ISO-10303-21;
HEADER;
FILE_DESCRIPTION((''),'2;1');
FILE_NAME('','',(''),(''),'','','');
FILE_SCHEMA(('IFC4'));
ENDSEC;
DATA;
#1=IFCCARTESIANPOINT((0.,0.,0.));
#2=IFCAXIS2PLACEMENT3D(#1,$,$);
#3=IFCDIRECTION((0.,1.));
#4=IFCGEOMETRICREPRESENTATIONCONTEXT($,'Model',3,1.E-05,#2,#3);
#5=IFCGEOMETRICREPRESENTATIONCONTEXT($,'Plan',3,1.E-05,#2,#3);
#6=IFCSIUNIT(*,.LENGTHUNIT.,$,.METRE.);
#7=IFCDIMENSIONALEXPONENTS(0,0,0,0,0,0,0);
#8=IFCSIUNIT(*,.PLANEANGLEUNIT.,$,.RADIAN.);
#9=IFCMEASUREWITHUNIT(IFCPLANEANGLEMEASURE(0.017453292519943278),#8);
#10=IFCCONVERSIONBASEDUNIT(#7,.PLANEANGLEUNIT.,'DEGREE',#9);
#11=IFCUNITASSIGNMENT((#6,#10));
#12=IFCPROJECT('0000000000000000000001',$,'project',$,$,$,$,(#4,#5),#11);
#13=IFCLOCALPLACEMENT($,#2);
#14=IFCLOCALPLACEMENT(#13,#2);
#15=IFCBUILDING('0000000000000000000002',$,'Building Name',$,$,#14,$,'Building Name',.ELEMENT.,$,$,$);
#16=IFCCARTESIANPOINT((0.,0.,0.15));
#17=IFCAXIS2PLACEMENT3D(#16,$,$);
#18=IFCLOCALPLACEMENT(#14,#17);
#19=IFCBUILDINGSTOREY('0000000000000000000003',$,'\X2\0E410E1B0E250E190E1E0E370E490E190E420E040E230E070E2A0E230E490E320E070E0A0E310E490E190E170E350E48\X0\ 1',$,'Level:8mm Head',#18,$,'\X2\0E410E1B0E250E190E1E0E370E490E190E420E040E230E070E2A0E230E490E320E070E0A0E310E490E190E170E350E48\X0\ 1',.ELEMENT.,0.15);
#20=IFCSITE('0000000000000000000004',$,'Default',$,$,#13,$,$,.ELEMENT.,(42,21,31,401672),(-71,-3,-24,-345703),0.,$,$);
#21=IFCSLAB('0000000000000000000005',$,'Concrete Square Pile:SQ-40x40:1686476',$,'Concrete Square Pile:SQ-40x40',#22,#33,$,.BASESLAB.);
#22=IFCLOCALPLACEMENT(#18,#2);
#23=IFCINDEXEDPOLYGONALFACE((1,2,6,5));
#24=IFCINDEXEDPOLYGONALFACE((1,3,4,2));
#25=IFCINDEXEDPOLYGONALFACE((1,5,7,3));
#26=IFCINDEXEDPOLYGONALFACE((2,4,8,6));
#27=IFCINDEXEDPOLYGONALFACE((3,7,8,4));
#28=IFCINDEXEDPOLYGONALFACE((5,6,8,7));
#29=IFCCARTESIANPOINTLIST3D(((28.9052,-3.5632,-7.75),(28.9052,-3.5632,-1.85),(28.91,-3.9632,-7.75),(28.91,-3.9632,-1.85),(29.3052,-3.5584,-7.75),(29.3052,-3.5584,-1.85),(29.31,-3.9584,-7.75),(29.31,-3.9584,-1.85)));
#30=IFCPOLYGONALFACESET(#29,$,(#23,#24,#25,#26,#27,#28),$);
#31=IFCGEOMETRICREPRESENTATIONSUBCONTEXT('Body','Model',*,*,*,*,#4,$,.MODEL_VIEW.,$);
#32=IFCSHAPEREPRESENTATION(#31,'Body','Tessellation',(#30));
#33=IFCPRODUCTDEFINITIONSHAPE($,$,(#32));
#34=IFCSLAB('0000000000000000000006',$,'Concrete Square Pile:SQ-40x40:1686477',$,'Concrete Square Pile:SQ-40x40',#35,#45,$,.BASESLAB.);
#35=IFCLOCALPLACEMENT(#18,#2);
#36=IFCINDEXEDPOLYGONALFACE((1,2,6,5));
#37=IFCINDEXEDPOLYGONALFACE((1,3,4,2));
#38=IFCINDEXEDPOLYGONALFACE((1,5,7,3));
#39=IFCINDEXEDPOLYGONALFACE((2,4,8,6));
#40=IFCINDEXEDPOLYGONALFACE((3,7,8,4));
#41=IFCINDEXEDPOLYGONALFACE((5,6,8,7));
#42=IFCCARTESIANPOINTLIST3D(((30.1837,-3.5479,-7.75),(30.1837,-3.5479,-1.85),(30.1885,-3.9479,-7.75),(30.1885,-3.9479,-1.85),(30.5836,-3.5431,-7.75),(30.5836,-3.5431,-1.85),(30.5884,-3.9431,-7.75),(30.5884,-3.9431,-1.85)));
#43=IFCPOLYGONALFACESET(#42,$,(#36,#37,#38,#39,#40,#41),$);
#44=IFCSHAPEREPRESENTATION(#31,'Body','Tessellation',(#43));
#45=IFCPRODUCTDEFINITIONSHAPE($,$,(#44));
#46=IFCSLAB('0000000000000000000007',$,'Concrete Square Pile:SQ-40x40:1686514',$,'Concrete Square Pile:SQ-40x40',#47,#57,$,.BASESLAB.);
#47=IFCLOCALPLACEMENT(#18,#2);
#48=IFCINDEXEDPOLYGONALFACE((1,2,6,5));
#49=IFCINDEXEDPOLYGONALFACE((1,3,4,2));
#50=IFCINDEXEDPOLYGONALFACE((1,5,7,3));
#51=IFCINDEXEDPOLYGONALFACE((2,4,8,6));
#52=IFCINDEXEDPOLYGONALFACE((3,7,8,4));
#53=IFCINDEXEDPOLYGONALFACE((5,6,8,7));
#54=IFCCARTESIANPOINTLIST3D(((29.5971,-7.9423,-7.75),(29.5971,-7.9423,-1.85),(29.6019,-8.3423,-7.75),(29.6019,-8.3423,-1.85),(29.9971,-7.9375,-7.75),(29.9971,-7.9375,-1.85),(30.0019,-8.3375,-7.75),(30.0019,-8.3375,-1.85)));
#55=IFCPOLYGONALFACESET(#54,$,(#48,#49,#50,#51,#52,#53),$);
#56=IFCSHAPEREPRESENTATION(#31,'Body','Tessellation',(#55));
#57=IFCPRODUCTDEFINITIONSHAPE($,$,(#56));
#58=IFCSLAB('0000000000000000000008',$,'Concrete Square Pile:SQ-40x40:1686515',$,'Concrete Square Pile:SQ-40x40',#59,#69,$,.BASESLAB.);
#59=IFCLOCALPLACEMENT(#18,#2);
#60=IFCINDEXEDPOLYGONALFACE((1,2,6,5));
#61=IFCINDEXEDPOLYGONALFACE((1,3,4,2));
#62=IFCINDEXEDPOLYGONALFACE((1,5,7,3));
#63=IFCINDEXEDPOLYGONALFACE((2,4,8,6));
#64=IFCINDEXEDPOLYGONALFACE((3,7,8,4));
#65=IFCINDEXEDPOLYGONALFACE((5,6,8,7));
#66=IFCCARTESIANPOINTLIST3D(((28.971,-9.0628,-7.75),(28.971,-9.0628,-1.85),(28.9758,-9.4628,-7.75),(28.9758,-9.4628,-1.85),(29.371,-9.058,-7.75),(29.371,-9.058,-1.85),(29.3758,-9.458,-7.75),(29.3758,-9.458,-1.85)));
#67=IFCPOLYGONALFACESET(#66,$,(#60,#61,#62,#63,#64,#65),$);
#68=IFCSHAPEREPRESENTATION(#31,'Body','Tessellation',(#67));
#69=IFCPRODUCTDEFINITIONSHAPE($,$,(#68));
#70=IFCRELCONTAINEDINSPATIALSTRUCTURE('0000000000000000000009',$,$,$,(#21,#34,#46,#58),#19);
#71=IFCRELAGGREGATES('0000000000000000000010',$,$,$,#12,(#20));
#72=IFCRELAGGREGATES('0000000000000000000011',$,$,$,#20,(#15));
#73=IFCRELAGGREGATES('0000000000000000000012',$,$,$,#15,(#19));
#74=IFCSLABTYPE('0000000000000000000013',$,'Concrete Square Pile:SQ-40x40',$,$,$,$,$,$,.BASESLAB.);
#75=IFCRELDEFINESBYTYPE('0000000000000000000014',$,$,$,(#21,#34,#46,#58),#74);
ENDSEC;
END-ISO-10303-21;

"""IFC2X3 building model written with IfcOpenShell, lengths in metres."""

from ifc_helpers import new_model, entity, si_unit, converted_unit, direction, frame, frame_2d, origin, place, context, subcontext, project, spatial, rectangle, extrude, type_object, element, save


model = new_model("IFC2X3")

# Units and contexts
model_context = context("Model", 3, precision=1e-05, world=origin(), true_north=direction((0.0, 1.0)))
plan_context = context("Plan", 3, precision=1e-05, world=origin(), true_north=direction((0.0, 1.0)))
body_context = subcontext(model_context, "Body", "Model", "MODEL_VIEW")
ifc_project = project(units=[si_unit("LENGTHUNIT", "METRE"), converted_unit("PLANEANGLEUNIT", "DEGREE", entity("IfcPlaneAngleMeasure", 0.017453292519943278), si_unit("PLANEANGLEUNIT", "RADIAN"), dimensions=[0, 0, 0, 0, 0, 0, 0])], contexts=[model_context, plan_context])

# Site, building, storey
site_placement = place(None, origin())
site = spatial("IfcSite", under=ifc_project, at=site_placement, Name="Default", CompositionType="ELEMENT", RefLatitude=(42, 21, 31, 401672), RefLongitude=(-71, -3, -24, -345703), RefElevation=0.0)
building_placement = place(site_placement, origin())
building = spatial("IfcBuilding", under=site, at=building_placement, Name="Building Name", LongName="Building Name", CompositionType="ELEMENT")
storey_placement = place(building_placement, frame((0.0, 0.0, 0.15)))
storey = spatial("IfcBuildingStorey", under=building, at=storey_placement, Name="แปลนพื้นโครงสร้างชั้นที่ 1", ObjectType="Level:8mm Head", LongName="แปลนพื้นโครงสร้างชั้นที่ 1", CompositionType="ELEMENT", Elevation=0.15)

# Slabs
slab_type_1 = type_object("IfcSlabType", Name="Concrete Square Pile:SQ-40x40", PredefinedType="BASESLAB")
slab_1_placement = place(storey_placement, origin())
element("IfcSlab", 1, at=slab_1_placement, inside=storey, type_object=slab_type_1, Name="Concrete Square Pile:SQ-40x40:1686476", ObjectType="Concrete Square Pile:SQ-40x40", PredefinedType="BASESLAB", context=body_context, shape_type="SweptSolid", body=[
    extrude(rectangle(XDim=0.4, YDim=0.4, at=frame_2d((0.0, 0.0), x_axis=(1.0, 0.0))), frame((29.1076, -3.7608, -7.75), z_axis=(0.0, 0.0, 1.0), x_axis=(-0.999928, -0.011969, 0.0)), (0.0, 0.0, 1.0), 5.9),
])
slab_2_placement = place(storey_placement, origin())
element("IfcSlab", 2, at=slab_2_placement, inside=storey, type_object=slab_type_1, Name="Concrete Square Pile:SQ-40x40:1686477", ObjectType="Concrete Square Pile:SQ-40x40", PredefinedType="BASESLAB", context=body_context, shape_type="SweptSolid", body=[
    extrude(rectangle(XDim=0.4, YDim=0.4, at=frame_2d((0.0, 0.0), x_axis=(1.0, 0.0))), frame((30.386, -3.7455, -7.75), z_axis=(0.0, 0.0, 1.0), x_axis=(-0.999928, -0.011969, 0.0)), (0.0, 0.0, 1.0), 5.9),
])
slab_3_placement = place(storey_placement, origin())
element("IfcSlab", 3, at=slab_3_placement, inside=storey, type_object=slab_type_1, Name="Concrete Square Pile:SQ-40x40:1686514", ObjectType="Concrete Square Pile:SQ-40x40", PredefinedType="BASESLAB", context=body_context, shape_type="SweptSolid", body=[
    extrude(rectangle(XDim=0.4, YDim=0.4, at=frame_2d((0.0, 0.0), x_axis=(1.0, 0.0))), frame((29.7995, -8.1399, -7.75), z_axis=(0.0, 0.0, 1.0), x_axis=(-0.999928, -0.011969, 0.0)), (0.0, 0.0, 1.0), 5.9),
])
slab_4_placement = place(storey_placement, origin())
element("IfcSlab", 4, at=slab_4_placement, inside=storey, type_object=slab_type_1, Name="Concrete Square Pile:SQ-40x40:1686515", ObjectType="Concrete Square Pile:SQ-40x40", PredefinedType="BASESLAB", context=body_context, shape_type="SweptSolid", body=[
    extrude(rectangle(XDim=0.4, YDim=0.4, at=frame_2d((0.0, 0.0), x_axis=(1.0, 0.0))), frame((29.1734, -9.2604, -7.75), z_axis=(0.0, 0.0, 1.0), x_axis=(-0.999928, -0.011969, 0.0)), (0.0, 0.0, 1.0), 5.9),
])

save(model, "model.ifc")
